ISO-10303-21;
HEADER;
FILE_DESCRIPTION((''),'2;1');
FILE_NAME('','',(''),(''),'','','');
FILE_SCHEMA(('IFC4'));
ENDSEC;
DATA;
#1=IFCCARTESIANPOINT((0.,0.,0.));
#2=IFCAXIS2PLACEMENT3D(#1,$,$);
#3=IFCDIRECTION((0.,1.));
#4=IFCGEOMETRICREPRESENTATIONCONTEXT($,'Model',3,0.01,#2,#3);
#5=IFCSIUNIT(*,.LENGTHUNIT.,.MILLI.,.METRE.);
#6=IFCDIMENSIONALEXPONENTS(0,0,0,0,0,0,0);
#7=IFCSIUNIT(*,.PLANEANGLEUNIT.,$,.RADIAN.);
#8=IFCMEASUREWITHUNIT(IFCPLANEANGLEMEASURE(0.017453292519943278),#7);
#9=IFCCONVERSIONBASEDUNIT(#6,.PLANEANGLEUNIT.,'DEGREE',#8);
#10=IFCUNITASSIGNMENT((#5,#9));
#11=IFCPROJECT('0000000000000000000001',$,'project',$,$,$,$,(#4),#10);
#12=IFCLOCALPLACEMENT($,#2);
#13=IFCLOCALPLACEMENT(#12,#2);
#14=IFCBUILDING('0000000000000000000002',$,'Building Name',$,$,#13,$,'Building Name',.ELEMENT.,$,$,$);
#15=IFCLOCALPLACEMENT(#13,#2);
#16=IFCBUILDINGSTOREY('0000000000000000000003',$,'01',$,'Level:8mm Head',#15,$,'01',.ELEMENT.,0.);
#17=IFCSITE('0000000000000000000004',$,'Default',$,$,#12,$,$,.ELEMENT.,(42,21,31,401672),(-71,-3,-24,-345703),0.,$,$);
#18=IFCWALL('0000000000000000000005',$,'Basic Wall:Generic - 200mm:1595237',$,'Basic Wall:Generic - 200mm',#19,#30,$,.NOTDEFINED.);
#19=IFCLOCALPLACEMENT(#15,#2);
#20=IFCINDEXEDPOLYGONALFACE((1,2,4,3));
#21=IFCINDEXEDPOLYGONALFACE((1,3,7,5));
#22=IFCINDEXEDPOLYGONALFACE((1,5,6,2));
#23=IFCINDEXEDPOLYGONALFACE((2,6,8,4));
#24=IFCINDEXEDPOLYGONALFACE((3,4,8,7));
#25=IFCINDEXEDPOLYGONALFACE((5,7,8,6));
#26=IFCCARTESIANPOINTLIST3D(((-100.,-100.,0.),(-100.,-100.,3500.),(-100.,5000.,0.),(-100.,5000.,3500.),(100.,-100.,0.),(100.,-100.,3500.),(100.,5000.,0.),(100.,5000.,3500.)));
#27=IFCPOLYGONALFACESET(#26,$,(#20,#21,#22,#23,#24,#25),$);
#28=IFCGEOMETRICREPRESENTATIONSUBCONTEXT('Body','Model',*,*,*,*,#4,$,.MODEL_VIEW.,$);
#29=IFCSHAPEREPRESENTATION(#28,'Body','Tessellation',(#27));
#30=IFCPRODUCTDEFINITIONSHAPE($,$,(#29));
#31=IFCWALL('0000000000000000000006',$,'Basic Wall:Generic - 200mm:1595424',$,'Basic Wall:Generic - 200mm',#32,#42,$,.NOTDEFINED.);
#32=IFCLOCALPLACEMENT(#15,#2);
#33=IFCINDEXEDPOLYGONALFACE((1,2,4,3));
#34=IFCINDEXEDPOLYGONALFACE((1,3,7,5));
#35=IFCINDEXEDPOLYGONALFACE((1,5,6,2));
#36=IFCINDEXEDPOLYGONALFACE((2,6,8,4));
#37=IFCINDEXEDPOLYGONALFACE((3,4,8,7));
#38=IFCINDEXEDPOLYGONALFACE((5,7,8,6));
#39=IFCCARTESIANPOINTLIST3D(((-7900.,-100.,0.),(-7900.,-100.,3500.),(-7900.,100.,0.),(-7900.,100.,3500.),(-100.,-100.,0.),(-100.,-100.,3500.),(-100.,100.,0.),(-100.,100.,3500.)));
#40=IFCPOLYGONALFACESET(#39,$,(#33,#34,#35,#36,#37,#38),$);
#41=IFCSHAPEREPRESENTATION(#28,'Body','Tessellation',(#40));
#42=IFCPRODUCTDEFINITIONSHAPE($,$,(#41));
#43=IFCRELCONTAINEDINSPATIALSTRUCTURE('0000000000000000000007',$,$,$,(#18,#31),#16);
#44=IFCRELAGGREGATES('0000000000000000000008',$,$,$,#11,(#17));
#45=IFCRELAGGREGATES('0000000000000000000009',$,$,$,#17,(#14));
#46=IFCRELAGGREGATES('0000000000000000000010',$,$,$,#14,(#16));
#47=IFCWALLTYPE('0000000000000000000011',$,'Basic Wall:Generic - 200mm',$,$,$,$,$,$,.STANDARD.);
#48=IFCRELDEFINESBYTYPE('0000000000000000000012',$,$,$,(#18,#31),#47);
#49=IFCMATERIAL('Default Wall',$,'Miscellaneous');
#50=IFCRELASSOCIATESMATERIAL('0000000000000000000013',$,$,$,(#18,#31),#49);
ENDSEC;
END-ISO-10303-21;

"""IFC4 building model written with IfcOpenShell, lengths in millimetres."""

from ifc_helpers import new_model, entity, si_unit, converted_unit, direction, frame, origin, place, context, subcontext, project, spatial, indexed_curve, outline, extrude, material, type_object, element, save


model = new_model("IFC4")

# Units and contexts
model_context = context("Model", 3, precision=0.01, world=origin(), true_north=direction((0.0, 1.0)))
body_context = subcontext(model_context, "Body", "Model", "MODEL_VIEW")
ifc_project = project(units=[si_unit("LENGTHUNIT", "METRE", prefix="MILLI"), converted_unit("PLANEANGLEUNIT", "DEGREE", entity("IfcPlaneAngleMeasure", 0.017453292519943278), si_unit("PLANEANGLEUNIT", "RADIAN"), dimensions=[0, 0, 0, 0, 0, 0, 0])], contexts=[model_context])

# Site, building, storey
site_placement = place(None, origin())
site = spatial("IfcSite", under=ifc_project, at=site_placement, Name="Default", CompositionType="ELEMENT", RefLatitude=(42, 21, 31, 401672), RefLongitude=(-71, -3, -24, -345703), RefElevation=0.0)
building_placement = place(site_placement, origin())
building = spatial("IfcBuilding", under=site, at=building_placement, Name="Building Name", LongName="Building Name", CompositionType="ELEMENT")
storey_placement = place(building_placement, origin())
storey = spatial("IfcBuildingStorey", under=building, at=storey_placement, Name="01", ObjectType="Level:8mm Head", LongName="01", CompositionType="ELEMENT", Elevation=0.0)

# Walls
ifc_material_1 = material(Name="Default Wall", Category="Miscellaneous")
wall_type = type_object("IfcWallType", Name="Basic Wall:Generic - 200mm", PredefinedType="STANDARD")
wall_1_placement = place(storey_placement, frame((0.0, 5000.0, 0.0), z_axis=(0.0, 0.0, 1.0), x_axis=(0.0, -1.0, 0.0)))
element("IfcWall", 1, at=wall_1_placement, inside=storey, type_object=wall_type, material=ifc_material_1, Name="Basic Wall:Generic - 200mm:1595237", ObjectType="Basic Wall:Generic - 200mm", PredefinedType="NOTDEFINED", context=body_context, shape_type="SweptSolid", body=[
    extrude(outline(indexed_curve([(5100.0, 100.0), (0.0, 100.0), (0.0, -100.0), (5100.0, -100.0), (5100.0, 100.0)], self_intersect=False)), origin(), (0.0, 0.0, 1.0), 3500.0),
])
wall_2_placement = place(storey_placement, frame((-100.0, 0.0, 0.0), z_axis=(0.0, 0.0, 1.0), x_axis=(-1.0, 0.0, 0.0)))
element("IfcWall", 2, at=wall_2_placement, inside=storey, type_object=wall_type, material=ifc_material_1, Name="Basic Wall:Generic - 200mm:1595424", ObjectType="Basic Wall:Generic - 200mm", PredefinedType="NOTDEFINED", context=body_context, shape_type="SweptSolid", body=[
    extrude(outline(indexed_curve([(7800.0, 100.0), (0.0, 100.0), (0.0, -100.0), (7800.0, -100.0), (7800.0, 100.0)], self_intersect=False)), origin(), (0.0, 0.0, 1.0), 3500.0),
])

save(model, "model.ifc")
